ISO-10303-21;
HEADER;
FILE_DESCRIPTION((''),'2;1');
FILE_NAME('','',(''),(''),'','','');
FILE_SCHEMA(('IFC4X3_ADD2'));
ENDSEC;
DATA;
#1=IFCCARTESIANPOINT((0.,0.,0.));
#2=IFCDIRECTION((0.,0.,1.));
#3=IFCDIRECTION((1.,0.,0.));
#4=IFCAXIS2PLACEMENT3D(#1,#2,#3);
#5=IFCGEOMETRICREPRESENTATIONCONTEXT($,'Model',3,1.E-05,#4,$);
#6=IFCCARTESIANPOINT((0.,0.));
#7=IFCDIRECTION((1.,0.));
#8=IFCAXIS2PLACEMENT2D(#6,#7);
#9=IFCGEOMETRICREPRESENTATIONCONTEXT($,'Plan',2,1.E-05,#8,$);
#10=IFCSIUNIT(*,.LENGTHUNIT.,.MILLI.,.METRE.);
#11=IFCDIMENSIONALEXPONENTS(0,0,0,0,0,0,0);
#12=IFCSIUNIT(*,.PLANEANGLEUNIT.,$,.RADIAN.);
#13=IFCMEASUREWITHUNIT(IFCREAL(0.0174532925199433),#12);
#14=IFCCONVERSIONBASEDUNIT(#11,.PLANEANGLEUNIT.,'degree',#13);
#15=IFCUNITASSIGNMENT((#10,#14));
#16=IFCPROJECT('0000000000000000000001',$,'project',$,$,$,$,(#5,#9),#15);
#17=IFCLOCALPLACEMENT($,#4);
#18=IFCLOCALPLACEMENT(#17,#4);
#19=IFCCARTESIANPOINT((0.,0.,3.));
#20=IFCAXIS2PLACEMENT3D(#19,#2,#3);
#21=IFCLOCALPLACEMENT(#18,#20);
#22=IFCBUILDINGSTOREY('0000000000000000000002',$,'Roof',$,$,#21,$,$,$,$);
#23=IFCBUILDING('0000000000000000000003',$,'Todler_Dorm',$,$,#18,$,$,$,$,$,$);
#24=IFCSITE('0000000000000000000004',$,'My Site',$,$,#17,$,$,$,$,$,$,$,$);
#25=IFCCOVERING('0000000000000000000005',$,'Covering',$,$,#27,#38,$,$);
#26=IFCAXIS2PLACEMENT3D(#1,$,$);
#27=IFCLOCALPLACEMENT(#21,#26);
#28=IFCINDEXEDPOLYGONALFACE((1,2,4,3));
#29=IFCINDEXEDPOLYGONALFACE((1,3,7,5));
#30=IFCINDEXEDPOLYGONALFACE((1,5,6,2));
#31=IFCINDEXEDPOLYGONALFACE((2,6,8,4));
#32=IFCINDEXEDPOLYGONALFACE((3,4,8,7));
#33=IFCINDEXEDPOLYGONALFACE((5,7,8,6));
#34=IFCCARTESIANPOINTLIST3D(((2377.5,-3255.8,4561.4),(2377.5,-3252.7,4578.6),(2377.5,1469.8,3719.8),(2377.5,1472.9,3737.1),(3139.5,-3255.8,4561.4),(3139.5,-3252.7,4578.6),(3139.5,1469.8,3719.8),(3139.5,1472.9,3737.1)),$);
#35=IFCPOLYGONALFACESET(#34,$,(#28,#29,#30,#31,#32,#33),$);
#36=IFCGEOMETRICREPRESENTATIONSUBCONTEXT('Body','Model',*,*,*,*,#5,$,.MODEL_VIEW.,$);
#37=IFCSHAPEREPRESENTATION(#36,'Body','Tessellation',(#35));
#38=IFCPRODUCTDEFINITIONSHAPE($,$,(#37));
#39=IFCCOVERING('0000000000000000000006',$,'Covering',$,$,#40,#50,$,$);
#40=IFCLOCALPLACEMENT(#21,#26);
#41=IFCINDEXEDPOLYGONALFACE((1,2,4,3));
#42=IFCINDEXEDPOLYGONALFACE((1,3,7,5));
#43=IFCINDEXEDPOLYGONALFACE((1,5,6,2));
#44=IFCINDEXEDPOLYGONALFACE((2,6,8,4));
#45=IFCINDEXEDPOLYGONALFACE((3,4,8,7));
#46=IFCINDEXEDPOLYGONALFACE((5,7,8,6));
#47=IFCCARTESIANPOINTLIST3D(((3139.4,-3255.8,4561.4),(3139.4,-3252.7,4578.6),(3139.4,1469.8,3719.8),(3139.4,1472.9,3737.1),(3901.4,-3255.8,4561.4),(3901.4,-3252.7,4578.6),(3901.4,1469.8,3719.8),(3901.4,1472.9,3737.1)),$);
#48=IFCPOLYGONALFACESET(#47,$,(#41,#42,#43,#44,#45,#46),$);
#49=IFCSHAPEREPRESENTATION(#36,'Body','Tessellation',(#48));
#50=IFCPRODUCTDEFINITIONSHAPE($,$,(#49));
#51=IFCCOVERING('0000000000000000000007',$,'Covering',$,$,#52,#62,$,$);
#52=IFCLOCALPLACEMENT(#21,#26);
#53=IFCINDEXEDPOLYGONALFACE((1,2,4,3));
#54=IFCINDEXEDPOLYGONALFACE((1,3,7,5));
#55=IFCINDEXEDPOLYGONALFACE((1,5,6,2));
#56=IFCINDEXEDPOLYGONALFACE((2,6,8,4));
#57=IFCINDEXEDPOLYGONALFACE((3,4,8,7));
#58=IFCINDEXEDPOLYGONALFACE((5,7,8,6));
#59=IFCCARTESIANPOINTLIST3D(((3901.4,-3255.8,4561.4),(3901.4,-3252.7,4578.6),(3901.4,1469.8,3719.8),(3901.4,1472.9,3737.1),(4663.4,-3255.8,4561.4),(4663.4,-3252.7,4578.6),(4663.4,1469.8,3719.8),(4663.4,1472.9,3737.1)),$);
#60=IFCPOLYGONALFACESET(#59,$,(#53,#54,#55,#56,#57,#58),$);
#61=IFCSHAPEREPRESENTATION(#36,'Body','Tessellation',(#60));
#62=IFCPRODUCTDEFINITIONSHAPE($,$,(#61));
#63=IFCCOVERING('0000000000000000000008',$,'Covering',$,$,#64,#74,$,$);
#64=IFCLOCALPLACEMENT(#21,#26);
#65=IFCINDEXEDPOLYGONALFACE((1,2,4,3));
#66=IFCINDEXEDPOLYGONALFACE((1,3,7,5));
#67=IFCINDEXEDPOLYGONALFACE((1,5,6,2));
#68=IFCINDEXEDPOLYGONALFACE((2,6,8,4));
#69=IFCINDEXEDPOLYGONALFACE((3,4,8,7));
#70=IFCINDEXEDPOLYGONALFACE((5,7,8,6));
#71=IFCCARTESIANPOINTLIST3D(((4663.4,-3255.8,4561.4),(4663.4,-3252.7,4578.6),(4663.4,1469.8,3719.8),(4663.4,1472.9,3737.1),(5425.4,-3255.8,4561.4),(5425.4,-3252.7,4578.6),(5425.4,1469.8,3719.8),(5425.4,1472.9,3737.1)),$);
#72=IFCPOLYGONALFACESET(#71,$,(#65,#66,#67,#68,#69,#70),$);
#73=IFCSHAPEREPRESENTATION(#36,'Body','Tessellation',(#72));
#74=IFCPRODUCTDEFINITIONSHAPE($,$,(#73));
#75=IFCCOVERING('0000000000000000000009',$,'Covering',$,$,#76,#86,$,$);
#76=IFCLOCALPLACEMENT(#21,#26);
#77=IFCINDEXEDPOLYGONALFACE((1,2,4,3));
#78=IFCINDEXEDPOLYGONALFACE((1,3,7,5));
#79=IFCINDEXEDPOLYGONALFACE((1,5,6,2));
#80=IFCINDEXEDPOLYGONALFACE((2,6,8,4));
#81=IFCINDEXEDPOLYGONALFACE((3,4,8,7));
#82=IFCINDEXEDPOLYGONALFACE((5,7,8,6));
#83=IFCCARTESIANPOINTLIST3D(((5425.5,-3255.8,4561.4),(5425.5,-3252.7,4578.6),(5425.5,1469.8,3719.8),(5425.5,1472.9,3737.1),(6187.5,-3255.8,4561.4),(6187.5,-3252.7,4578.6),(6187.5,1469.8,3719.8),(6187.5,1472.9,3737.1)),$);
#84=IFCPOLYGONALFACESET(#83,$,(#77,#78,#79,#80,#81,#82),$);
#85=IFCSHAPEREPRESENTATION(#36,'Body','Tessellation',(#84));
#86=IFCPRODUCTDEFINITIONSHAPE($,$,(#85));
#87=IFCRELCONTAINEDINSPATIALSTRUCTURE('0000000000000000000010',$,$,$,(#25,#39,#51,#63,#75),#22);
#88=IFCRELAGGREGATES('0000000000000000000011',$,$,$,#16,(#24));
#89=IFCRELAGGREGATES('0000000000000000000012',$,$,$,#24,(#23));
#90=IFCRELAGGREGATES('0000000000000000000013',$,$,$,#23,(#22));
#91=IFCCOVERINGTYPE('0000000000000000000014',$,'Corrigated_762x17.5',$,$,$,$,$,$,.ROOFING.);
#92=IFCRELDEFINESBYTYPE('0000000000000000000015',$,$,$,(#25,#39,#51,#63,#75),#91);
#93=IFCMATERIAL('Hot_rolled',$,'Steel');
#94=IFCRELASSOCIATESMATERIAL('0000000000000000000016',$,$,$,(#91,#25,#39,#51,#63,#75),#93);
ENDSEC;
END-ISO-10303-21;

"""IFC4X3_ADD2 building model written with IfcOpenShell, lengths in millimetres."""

from ifc_helpers import new_model, entity, si_unit, converted_unit, frame, origin_with_axes, origin_2d_with_axis, place, context, subcontext, project, spatial, rectangle, extrude, material, material_profile, profile_set, profile_usage, type_object, element, save


model = new_model("IFC4X3_ADD2")

# Units and contexts
model_context = context("Model", 3, precision=1e-05, world=origin_with_axes())
plan_context = context("Plan", 2, precision=1e-05, world=origin_2d_with_axis())
body_context = subcontext(model_context, "Body", "Model", "MODEL_VIEW")
ifc_project = project(units=[si_unit("LENGTHUNIT", "METRE", prefix="MILLI"), converted_unit("PLANEANGLEUNIT", "degree", entity("IfcReal", 0.0174532925199433), si_unit("PLANEANGLEUNIT", "RADIAN"), dimensions=[0, 0, 0, 0, 0, 0, 0])], contexts=[model_context, plan_context])

# Site, building, storey
site_placement = place(None, origin_with_axes())
site = spatial("IfcSite", under=ifc_project, at=site_placement, Name="My Site")
building_placement = place(site_placement, origin_with_axes())
building = spatial("IfcBuilding", under=site, at=building_placement, Name="Todler_Dorm")
storey_placement = place(building_placement, frame((0.0, 0.0, 3.0), z_axis=(0.0, 0.0, 1.0), x_axis=(1.0, 0.0, 0.0)))
storey = spatial("IfcBuildingStorey", under=building, at=storey_placement, Name="Roof")

# Coverings
ifc_material_1 = material(Name="Hot_rolled", Category="Steel")
ifc_material_profile = material_profile(ifc_material_1, rectangle(XDim=762.0, YDim=17.5))
ifc_profile_set = profile_set([ifc_material_profile])
covering_type = type_object("IfcCoveringType", Name="Corrigated_762x17.5", PredefinedType="ROOFING", material=ifc_profile_set)
ifc_profile_usage_1 = profile_usage(ifc_profile_set, cardinal=5)
covering_1_placement = place(storey_placement, frame((2758.5, 1471.4, 3728.4), z_axis=(0.0, -0.98451, 0.175329), x_axis=(1.0, 0.0, 0.0)))
element("IfcCovering", 1, at=covering_1_placement, inside=storey, type_object=covering_type, material=ifc_profile_usage_1, Name="Covering", context=body_context, shape_type="SweptSolid", body=[
    extrude(rectangle(XDim=762.0, YDim=17.5), origin_with_axes(), (0.0, 0.0, 1.0), 4800.0),
])
ifc_profile_usage_2 = profile_usage(ifc_profile_set, cardinal=5)
covering_2_placement = place(storey_placement, frame((3520.4, 1471.4, 3728.4), z_axis=(0.0, -0.98451, 0.175329), x_axis=(1.0, 0.0, 0.0)))
element("IfcCovering", 2, at=covering_2_placement, inside=storey, type_object=covering_type, material=ifc_profile_usage_2, Name="Covering", context=body_context, shape_type="SweptSolid", body=[
    extrude(rectangle(XDim=762.0, YDim=17.5), origin_with_axes(), (0.0, 0.0, 1.0), 4800.0),
])
ifc_profile_usage_3 = profile_usage(ifc_profile_set, cardinal=5)
covering_3_placement = place(storey_placement, frame((4282.4, 1471.4, 3728.4), z_axis=(0.0, -0.98451, 0.175329), x_axis=(1.0, 0.0, 0.0)))
element("IfcCovering", 3, at=covering_3_placement, inside=storey, type_object=covering_type, material=ifc_profile_usage_3, Name="Covering", context=body_context, shape_type="SweptSolid", body=[
    extrude(rectangle(XDim=762.0, YDim=17.5), origin_with_axes(), (0.0, 0.0, 1.0), 4800.0),
])
ifc_profile_usage_4 = profile_usage(ifc_profile_set, cardinal=5)
covering_4_placement = place(storey_placement, frame((5044.4, 1471.4, 3728.4), z_axis=(0.0, -0.98451, 0.175329), x_axis=(1.0, 0.0, 0.0)))
element("IfcCovering", 4, at=covering_4_placement, inside=storey, type_object=covering_type, material=ifc_profile_usage_4, Name="Covering", context=body_context, shape_type="SweptSolid", body=[
    extrude(rectangle(XDim=762.0, YDim=17.5), origin_with_axes(), (0.0, 0.0, 1.0), 4800.0),
])
ifc_profile_usage_5 = profile_usage(ifc_profile_set, cardinal=5)
covering_5_placement = place(storey_placement, frame((5806.5, 1471.4, 3728.4), z_axis=(0.0, -0.98451, 0.175329), x_axis=(1.0, 0.0, 0.0)))
element("IfcCovering", 5, at=covering_5_placement, inside=storey, type_object=covering_type, material=ifc_profile_usage_5, Name="Covering", context=body_context, shape_type="SweptSolid", body=[
    extrude(rectangle(XDim=762.0, YDim=17.5), origin_with_axes(), (0.0, 0.0, 1.0), 4800.0),
])

save(model, "model.ifc")
